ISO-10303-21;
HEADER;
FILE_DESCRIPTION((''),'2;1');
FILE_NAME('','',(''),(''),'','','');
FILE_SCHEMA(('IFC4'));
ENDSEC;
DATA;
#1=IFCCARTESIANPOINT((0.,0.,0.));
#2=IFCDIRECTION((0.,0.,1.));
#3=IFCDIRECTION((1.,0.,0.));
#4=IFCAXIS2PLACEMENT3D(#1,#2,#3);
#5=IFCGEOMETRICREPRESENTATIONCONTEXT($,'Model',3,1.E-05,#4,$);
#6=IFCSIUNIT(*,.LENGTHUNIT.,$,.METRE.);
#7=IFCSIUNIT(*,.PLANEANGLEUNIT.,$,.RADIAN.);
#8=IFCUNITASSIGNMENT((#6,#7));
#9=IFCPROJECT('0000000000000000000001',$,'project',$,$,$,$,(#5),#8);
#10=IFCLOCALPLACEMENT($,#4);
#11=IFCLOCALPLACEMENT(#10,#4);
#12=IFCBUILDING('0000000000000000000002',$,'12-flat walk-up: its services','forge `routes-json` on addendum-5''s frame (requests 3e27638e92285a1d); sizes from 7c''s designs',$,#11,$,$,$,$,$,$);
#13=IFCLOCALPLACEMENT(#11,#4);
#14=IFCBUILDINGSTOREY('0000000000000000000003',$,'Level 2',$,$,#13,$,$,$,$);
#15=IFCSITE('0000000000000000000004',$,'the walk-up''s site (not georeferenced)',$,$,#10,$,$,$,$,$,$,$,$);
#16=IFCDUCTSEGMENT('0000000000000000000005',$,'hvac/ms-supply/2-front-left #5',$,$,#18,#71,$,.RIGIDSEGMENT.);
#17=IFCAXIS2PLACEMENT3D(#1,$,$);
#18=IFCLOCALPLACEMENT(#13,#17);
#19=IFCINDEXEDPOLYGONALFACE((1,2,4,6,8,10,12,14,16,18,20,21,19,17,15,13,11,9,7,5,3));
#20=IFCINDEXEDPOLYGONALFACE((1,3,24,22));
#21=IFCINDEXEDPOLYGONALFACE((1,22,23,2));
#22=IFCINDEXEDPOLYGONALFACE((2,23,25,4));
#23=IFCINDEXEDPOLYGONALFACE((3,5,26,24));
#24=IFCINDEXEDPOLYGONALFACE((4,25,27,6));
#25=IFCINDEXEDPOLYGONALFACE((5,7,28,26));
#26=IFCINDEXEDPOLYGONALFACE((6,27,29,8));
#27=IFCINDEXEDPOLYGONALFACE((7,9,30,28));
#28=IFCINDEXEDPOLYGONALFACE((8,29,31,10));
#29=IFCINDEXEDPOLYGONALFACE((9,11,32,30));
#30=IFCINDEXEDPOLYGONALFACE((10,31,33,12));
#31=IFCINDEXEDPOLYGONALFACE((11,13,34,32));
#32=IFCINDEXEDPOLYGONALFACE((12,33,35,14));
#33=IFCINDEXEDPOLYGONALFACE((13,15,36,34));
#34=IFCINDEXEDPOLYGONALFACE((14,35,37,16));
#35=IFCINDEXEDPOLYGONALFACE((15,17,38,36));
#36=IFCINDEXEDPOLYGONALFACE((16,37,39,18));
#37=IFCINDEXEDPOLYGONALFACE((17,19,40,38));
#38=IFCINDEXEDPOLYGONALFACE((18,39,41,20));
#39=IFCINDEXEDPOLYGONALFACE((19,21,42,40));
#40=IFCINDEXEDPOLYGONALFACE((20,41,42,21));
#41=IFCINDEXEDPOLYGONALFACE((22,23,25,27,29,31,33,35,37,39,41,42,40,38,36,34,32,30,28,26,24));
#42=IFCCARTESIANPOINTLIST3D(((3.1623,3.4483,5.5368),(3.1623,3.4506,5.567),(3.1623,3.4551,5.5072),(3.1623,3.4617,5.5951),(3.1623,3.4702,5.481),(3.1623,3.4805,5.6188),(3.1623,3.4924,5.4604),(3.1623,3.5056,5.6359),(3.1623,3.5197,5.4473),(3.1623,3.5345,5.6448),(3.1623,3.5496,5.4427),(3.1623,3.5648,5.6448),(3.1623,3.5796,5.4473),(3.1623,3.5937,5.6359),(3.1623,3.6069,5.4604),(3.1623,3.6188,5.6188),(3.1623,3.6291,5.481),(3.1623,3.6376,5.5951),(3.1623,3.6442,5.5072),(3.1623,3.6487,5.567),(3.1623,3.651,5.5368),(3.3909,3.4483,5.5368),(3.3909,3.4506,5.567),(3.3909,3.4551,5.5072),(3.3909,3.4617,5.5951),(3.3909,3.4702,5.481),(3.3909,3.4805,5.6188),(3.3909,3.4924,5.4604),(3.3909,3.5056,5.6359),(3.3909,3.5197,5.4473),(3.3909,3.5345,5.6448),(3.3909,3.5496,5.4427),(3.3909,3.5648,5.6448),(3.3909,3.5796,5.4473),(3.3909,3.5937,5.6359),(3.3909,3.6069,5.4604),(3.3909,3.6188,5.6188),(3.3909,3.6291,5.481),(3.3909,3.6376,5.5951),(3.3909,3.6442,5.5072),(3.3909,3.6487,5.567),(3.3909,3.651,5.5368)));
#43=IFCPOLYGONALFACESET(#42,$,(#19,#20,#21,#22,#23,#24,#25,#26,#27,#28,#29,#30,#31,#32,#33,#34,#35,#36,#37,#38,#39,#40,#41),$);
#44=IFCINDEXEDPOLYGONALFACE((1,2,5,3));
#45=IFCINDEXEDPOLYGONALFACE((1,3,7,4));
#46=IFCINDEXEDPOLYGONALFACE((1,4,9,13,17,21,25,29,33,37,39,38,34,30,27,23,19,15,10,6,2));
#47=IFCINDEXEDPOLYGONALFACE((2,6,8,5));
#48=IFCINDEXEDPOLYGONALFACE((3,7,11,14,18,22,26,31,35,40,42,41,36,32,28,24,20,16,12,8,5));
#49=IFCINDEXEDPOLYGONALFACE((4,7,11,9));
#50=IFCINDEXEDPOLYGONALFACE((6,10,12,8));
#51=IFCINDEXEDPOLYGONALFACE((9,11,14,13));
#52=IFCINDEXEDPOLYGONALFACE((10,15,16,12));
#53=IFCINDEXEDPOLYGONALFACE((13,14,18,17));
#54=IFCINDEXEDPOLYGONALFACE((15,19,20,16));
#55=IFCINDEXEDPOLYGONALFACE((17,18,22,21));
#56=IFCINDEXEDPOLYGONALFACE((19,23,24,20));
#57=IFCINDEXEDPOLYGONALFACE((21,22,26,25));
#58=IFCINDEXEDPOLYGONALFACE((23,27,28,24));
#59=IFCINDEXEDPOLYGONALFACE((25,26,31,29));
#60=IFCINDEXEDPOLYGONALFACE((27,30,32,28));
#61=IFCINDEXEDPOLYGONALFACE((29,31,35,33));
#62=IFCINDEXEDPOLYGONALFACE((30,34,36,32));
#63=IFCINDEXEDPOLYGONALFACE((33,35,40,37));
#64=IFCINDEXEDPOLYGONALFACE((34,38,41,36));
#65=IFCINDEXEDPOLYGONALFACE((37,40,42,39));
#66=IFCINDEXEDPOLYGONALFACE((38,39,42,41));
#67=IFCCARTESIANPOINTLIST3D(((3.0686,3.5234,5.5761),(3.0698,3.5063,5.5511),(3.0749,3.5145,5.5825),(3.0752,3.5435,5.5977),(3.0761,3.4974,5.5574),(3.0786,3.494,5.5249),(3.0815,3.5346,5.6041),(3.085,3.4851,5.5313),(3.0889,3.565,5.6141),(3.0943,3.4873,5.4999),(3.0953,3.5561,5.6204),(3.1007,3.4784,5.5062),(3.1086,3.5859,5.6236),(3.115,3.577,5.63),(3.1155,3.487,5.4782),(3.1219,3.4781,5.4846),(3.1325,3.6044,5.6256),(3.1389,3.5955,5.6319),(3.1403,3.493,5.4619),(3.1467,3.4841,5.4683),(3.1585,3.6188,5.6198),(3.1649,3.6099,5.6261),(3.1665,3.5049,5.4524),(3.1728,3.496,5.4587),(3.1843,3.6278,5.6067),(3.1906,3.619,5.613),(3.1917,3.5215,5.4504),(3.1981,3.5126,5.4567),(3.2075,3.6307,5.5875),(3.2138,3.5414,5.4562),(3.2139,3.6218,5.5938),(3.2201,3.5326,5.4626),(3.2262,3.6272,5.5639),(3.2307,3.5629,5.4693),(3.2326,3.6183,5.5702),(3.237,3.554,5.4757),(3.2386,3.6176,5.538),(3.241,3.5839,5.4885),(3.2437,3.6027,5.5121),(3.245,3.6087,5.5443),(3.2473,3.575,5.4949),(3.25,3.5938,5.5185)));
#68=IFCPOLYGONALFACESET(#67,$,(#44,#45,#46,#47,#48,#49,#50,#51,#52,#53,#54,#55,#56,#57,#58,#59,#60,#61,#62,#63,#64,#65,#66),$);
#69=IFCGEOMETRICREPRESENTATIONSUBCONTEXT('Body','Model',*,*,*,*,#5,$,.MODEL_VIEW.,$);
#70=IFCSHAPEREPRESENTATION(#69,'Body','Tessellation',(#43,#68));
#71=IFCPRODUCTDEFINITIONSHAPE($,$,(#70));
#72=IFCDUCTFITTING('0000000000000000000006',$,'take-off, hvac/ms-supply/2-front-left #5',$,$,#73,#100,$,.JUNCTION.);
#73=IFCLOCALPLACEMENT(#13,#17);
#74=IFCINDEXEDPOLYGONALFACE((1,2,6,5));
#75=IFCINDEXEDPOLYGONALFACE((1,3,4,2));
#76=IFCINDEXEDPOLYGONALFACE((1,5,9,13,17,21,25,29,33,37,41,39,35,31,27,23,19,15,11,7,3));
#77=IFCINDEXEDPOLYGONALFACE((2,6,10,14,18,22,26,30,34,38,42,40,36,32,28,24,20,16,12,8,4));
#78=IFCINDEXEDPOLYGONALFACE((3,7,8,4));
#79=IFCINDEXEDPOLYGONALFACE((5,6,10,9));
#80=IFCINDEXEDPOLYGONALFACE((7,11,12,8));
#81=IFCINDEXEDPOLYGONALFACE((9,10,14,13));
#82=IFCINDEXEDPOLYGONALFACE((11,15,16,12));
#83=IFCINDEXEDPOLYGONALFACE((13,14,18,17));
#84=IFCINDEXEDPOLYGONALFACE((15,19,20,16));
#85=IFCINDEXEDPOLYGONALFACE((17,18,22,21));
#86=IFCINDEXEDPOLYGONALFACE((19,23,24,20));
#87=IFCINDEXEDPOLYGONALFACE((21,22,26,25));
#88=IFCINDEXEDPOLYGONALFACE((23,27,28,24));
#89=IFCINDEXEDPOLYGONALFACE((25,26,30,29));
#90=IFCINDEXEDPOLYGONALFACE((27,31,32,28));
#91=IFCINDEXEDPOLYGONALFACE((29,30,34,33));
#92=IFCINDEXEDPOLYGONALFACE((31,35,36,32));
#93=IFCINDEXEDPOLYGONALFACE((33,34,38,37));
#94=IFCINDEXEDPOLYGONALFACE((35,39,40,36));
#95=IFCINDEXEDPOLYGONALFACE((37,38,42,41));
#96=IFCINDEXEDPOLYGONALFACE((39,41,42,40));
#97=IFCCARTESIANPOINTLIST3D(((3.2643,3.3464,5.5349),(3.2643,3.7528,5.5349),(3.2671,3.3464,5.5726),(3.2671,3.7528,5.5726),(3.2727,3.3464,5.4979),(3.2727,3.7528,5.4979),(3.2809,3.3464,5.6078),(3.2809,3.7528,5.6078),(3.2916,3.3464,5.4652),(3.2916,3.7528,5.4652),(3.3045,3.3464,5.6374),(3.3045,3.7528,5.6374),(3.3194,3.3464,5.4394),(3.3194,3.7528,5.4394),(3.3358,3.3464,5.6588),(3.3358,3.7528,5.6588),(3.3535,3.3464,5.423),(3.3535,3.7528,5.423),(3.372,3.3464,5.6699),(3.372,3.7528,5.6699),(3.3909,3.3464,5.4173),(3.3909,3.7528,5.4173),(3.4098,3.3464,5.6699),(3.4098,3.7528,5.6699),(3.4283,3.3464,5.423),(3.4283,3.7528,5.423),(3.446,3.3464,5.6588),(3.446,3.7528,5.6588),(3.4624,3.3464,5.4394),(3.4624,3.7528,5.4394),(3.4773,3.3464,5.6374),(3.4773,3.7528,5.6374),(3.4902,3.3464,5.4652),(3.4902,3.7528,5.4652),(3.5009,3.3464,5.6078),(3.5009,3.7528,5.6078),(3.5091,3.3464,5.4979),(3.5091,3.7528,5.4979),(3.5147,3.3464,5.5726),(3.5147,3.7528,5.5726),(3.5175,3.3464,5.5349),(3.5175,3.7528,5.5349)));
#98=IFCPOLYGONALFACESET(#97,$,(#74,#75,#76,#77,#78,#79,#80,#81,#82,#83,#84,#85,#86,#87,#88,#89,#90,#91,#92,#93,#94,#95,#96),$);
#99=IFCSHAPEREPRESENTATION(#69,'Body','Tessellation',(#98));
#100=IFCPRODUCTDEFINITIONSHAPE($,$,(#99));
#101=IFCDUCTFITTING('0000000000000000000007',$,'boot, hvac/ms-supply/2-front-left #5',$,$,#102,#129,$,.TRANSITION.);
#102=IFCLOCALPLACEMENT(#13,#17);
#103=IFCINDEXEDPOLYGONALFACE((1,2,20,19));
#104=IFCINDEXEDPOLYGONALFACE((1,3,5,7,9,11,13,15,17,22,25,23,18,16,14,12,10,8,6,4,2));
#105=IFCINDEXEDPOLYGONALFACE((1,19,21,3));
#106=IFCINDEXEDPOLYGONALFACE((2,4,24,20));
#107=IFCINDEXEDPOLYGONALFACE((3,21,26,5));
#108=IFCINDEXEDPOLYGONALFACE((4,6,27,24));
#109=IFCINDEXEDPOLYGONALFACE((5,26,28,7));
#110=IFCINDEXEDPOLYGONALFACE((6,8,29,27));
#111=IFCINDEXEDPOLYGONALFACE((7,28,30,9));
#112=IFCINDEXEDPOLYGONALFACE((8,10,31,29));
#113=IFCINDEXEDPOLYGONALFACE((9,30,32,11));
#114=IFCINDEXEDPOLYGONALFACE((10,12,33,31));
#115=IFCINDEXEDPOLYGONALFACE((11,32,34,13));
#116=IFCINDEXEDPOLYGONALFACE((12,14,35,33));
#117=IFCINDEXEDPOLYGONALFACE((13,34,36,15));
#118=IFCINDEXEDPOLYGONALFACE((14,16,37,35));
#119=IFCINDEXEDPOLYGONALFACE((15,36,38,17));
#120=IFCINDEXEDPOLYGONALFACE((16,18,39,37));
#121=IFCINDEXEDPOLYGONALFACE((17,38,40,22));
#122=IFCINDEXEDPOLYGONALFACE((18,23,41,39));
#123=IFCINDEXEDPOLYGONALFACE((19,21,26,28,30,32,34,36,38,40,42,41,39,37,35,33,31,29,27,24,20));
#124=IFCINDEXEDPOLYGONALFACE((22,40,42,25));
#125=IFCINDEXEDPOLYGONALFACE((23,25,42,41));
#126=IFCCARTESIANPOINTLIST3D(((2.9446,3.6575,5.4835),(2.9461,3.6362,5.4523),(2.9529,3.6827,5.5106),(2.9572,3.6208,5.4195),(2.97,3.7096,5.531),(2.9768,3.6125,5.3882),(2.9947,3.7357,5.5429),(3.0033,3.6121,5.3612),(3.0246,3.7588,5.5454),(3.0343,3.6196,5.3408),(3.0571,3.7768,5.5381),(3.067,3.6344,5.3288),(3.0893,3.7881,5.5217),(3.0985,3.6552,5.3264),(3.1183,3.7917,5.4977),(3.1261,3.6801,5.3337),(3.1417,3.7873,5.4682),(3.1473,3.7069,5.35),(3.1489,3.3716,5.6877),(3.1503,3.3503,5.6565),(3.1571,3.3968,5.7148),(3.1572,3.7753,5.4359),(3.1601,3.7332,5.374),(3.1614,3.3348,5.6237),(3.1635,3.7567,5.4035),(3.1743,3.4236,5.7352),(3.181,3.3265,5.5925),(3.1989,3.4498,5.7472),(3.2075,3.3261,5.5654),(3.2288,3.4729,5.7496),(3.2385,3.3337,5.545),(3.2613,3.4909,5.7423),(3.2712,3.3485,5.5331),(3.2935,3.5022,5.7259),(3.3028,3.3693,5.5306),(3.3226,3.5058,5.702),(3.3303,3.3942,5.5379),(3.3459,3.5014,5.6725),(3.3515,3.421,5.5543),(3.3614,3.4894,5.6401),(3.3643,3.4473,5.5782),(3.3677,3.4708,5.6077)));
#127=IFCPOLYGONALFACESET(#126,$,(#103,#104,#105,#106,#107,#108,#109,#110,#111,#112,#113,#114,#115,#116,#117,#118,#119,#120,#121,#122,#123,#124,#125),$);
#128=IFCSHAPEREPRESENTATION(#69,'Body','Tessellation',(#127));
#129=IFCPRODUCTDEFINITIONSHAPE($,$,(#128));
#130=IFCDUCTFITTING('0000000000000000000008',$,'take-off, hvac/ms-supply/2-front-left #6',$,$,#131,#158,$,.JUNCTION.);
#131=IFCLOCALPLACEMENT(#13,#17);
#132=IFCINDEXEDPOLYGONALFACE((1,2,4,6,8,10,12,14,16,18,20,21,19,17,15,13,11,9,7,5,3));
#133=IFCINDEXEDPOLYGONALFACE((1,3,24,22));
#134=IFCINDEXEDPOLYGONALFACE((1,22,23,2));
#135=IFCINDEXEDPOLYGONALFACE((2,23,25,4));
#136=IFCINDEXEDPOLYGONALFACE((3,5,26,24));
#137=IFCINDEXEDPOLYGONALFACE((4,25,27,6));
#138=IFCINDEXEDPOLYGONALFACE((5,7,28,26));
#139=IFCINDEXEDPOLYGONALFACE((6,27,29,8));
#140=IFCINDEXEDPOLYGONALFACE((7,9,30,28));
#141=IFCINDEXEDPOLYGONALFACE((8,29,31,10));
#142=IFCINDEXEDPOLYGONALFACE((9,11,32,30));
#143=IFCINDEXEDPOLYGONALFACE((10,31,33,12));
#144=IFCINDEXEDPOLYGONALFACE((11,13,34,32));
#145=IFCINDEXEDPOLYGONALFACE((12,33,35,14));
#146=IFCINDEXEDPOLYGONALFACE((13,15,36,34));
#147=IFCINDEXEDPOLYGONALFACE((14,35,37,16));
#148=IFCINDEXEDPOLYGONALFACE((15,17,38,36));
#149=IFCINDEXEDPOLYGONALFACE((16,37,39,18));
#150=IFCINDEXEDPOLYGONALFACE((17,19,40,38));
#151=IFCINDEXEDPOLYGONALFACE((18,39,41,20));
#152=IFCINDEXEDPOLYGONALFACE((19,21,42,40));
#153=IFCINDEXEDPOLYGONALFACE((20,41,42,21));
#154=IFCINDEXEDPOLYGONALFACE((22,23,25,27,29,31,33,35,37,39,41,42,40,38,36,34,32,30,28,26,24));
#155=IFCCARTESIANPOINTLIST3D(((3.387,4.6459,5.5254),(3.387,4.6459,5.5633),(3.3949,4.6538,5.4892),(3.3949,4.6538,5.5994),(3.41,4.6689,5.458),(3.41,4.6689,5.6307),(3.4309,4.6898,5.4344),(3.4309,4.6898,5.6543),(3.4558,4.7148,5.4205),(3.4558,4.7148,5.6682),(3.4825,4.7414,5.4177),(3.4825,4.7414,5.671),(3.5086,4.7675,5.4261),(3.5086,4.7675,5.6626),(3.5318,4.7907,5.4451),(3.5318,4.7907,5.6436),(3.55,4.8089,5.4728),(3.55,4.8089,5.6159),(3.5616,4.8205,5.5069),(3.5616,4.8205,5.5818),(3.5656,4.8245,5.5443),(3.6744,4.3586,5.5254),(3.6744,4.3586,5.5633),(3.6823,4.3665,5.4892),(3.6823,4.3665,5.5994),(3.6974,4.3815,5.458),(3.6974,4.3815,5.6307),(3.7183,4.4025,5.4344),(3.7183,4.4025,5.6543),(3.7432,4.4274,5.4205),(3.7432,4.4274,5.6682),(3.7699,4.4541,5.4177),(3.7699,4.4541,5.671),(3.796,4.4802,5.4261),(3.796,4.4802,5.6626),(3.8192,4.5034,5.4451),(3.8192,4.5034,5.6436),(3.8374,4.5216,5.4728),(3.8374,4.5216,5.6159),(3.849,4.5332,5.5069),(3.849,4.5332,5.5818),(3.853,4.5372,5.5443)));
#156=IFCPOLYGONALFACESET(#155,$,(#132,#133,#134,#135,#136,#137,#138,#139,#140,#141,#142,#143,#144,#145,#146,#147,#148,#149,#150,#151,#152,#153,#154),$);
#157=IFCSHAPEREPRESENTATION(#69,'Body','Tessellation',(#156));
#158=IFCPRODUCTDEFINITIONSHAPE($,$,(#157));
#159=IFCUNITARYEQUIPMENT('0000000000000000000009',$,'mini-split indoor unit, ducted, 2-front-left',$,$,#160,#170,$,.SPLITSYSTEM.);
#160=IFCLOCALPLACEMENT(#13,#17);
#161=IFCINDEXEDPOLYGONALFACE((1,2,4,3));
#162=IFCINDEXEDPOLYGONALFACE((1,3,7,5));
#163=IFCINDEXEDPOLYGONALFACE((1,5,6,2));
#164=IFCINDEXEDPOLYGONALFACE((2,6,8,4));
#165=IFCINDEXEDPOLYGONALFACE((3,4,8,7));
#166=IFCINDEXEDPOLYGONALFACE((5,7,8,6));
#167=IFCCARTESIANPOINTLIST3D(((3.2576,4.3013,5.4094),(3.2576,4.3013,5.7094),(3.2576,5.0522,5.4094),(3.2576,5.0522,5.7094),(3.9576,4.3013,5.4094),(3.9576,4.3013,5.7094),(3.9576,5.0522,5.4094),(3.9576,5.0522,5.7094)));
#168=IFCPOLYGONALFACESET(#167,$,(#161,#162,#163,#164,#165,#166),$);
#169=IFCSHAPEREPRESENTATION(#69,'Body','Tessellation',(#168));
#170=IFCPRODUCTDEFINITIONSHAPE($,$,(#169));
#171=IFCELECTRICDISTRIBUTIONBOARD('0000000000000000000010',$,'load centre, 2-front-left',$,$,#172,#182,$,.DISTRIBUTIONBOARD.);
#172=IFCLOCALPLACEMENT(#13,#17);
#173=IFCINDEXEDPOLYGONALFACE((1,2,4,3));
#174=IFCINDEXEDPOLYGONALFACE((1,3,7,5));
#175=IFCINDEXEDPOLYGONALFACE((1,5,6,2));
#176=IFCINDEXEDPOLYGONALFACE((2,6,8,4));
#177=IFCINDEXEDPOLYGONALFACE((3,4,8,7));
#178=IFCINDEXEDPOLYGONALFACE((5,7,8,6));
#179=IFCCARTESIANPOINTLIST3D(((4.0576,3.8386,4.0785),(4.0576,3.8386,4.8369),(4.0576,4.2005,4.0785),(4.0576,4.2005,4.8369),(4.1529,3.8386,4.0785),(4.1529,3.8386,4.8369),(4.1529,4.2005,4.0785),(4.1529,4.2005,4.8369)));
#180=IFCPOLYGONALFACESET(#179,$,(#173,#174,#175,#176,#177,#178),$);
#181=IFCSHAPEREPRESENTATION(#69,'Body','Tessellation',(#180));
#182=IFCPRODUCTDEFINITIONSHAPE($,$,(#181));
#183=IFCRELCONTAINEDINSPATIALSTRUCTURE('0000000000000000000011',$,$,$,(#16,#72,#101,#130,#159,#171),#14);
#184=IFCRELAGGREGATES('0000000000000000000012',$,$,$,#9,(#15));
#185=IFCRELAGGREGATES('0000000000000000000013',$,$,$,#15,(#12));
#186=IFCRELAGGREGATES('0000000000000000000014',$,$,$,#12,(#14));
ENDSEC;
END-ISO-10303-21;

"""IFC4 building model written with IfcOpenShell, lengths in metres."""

from ifc_helpers import new_model, entity, si_unit, frame, frame_2d, origin, origin_with_axes, place, context, subcontext, project, spatial, rectangle, extrude, element, save


model = new_model("IFC4")

# Units and contexts
model_context = context("Model", 3, precision=1e-05, world=origin_with_axes())
body_context = subcontext(model_context, "Body", "Model", "MODEL_VIEW")
ifc_project = project(units=[si_unit("LENGTHUNIT", "METRE"), si_unit("PLANEANGLEUNIT", "RADIAN")], contexts=[model_context])

# Site, building, storey
site_placement = place(None, origin_with_axes())
site = spatial("IfcSite", under=ifc_project, at=site_placement, Name="the walk-up's site (not georeferenced)")
building_placement = place(site_placement, origin_with_axes())
building = spatial("IfcBuilding", under=site, at=building_placement, Name="12-flat walk-up: its services", Description="forge `routes-json` on addendum-5's frame (requests 3e27638e92285a1d); sizes from 7c's designs")
storey_placement = place(building_placement, origin_with_axes())
storey = spatial("IfcBuildingStorey", under=building, at=storey_placement, Name="Level 2")

# Duct segment
duct_segment_1_placement = place(storey_placement, frame((3.3909, 3.5496, 5.5443), z_axis=(0.0, 0.0, 1.0), x_axis=(1.0, 0.0, 0.0)))
element("IfcDuctSegment", 1, at=duct_segment_1_placement, inside=storey, Name="hvac/ms-supply/2-front-left #5", PredefinedType="RIGIDSEGMENT", context=body_context, shape_type="AdvancedSweptSolid", body=[
    entity("IfcSweptDiskSolid", entity("IfcPolyline", [entity("IfcCartesianPoint", [0.0, 0.0, 0.0]), entity("IfcCartesianPoint", [-0.2286, 0.0, 0.0])]), 0.1016),
    entity("IfcSweptDiskSolid", entity("IfcPolyline", [entity("IfcCartesianPoint", [-0.2286, 0.0, 0.0]), entity("IfcCartesianPoint", [-0.2349, 0.0089, -0.0063])]), 0.1016),
])

# Duct fittings
duct_fitting_1_placement = place(storey_placement, frame((3.3909, 3.7528, 5.5443), z_axis=(0.0, 0.0, 1.0), x_axis=(1.0, 0.0, 0.0)))
element("IfcDuctFitting", 2, at=duct_fitting_1_placement, inside=storey, Name="take-off, hvac/ms-supply/2-front-left #5", PredefinedType="JUNCTION", context=body_context, shape_type="AdvancedSweptSolid", body=[
    entity("IfcSweptDiskSolid", entity("IfcPolyline", [entity("IfcCartesianPoint", [0.0, 0.0, 0.0]), entity("IfcCartesianPoint", [0.0, -0.4064, 0.0])]), 0.127),
])
duct_fitting_2_placement = place(storey_placement, frame((3.2581, 3.4156, 5.6401), z_axis=(0.0, 0.0, 1.0), x_axis=(1.0, 0.0, 0.0)))
element("IfcDuctFitting", 3, at=duct_fitting_2_placement, inside=storey, Name="boot, hvac/ms-supply/2-front-left #5", PredefinedType="TRANSITION", context=body_context, shape_type="AdvancedSweptSolid", body=[
    entity("IfcSweptDiskSolid", entity("IfcPolyline", [entity("IfcCartesianPoint", [0.0, 0.0, 0.0]), entity("IfcCartesianPoint", [-0.2042, 0.2859, -0.2042])]), 0.127),
])
duct_fitting_3_placement = place(storey_placement, frame((3.7632, 4.4474, 5.5443), z_axis=(0.0, 0.0, 1.0), x_axis=(1.0, 0.0, 0.0)))
element("IfcDuctFitting", 4, at=duct_fitting_3_placement, inside=storey, Name="take-off, hvac/ms-supply/2-front-left #6", PredefinedType="JUNCTION", context=body_context, shape_type="AdvancedSweptSolid", body=[
    entity("IfcSweptDiskSolid", entity("IfcPolyline", [entity("IfcCartesianPoint", [0.0, 0.0, 0.0]), entity("IfcCartesianPoint", [-0.2874, 0.2874, 0.0])]), 0.127),
])

# Unitary equipment
unitary_equipment_placement = place(storey_placement, frame((3.2576, 4.3013, 5.4094), z_axis=(0.0, 0.0, 1.0), x_axis=(1.0, 0.0, 0.0)))
element("IfcUnitaryEquipment", 5, at=unitary_equipment_placement, inside=storey, Name="mini-split indoor unit, ducted, 2-front-left", PredefinedType="SPLITSYSTEM", context=body_context, shape_type="SweptSolid", body=[
    extrude(rectangle(XDim=0.7001, YDim=0.7509, at=frame_2d((0.35, 0.3754))), origin(), (0.0, 0.0, 1.0), 0.3),
])

# Electric distribution board
electric_distribution_board_placement = place(storey_placement, frame((4.0576, 3.8386, 4.0785), z_axis=(0.0, 0.0, 1.0), x_axis=(1.0, 0.0, 0.0)))
element("IfcElectricDistributionBoard", 6, at=electric_distribution_board_placement, inside=storey, Name="load centre, 2-front-left", PredefinedType="DISTRIBUTIONBOARD", context=body_context, shape_type="SweptSolid", body=[
    extrude(rectangle(XDim=0.0953, YDim=0.362, at=frame_2d((0.0476, 0.181))), origin(), (0.0, 0.0, 1.0), 0.7584),
])

save(model, "model.ifc")
